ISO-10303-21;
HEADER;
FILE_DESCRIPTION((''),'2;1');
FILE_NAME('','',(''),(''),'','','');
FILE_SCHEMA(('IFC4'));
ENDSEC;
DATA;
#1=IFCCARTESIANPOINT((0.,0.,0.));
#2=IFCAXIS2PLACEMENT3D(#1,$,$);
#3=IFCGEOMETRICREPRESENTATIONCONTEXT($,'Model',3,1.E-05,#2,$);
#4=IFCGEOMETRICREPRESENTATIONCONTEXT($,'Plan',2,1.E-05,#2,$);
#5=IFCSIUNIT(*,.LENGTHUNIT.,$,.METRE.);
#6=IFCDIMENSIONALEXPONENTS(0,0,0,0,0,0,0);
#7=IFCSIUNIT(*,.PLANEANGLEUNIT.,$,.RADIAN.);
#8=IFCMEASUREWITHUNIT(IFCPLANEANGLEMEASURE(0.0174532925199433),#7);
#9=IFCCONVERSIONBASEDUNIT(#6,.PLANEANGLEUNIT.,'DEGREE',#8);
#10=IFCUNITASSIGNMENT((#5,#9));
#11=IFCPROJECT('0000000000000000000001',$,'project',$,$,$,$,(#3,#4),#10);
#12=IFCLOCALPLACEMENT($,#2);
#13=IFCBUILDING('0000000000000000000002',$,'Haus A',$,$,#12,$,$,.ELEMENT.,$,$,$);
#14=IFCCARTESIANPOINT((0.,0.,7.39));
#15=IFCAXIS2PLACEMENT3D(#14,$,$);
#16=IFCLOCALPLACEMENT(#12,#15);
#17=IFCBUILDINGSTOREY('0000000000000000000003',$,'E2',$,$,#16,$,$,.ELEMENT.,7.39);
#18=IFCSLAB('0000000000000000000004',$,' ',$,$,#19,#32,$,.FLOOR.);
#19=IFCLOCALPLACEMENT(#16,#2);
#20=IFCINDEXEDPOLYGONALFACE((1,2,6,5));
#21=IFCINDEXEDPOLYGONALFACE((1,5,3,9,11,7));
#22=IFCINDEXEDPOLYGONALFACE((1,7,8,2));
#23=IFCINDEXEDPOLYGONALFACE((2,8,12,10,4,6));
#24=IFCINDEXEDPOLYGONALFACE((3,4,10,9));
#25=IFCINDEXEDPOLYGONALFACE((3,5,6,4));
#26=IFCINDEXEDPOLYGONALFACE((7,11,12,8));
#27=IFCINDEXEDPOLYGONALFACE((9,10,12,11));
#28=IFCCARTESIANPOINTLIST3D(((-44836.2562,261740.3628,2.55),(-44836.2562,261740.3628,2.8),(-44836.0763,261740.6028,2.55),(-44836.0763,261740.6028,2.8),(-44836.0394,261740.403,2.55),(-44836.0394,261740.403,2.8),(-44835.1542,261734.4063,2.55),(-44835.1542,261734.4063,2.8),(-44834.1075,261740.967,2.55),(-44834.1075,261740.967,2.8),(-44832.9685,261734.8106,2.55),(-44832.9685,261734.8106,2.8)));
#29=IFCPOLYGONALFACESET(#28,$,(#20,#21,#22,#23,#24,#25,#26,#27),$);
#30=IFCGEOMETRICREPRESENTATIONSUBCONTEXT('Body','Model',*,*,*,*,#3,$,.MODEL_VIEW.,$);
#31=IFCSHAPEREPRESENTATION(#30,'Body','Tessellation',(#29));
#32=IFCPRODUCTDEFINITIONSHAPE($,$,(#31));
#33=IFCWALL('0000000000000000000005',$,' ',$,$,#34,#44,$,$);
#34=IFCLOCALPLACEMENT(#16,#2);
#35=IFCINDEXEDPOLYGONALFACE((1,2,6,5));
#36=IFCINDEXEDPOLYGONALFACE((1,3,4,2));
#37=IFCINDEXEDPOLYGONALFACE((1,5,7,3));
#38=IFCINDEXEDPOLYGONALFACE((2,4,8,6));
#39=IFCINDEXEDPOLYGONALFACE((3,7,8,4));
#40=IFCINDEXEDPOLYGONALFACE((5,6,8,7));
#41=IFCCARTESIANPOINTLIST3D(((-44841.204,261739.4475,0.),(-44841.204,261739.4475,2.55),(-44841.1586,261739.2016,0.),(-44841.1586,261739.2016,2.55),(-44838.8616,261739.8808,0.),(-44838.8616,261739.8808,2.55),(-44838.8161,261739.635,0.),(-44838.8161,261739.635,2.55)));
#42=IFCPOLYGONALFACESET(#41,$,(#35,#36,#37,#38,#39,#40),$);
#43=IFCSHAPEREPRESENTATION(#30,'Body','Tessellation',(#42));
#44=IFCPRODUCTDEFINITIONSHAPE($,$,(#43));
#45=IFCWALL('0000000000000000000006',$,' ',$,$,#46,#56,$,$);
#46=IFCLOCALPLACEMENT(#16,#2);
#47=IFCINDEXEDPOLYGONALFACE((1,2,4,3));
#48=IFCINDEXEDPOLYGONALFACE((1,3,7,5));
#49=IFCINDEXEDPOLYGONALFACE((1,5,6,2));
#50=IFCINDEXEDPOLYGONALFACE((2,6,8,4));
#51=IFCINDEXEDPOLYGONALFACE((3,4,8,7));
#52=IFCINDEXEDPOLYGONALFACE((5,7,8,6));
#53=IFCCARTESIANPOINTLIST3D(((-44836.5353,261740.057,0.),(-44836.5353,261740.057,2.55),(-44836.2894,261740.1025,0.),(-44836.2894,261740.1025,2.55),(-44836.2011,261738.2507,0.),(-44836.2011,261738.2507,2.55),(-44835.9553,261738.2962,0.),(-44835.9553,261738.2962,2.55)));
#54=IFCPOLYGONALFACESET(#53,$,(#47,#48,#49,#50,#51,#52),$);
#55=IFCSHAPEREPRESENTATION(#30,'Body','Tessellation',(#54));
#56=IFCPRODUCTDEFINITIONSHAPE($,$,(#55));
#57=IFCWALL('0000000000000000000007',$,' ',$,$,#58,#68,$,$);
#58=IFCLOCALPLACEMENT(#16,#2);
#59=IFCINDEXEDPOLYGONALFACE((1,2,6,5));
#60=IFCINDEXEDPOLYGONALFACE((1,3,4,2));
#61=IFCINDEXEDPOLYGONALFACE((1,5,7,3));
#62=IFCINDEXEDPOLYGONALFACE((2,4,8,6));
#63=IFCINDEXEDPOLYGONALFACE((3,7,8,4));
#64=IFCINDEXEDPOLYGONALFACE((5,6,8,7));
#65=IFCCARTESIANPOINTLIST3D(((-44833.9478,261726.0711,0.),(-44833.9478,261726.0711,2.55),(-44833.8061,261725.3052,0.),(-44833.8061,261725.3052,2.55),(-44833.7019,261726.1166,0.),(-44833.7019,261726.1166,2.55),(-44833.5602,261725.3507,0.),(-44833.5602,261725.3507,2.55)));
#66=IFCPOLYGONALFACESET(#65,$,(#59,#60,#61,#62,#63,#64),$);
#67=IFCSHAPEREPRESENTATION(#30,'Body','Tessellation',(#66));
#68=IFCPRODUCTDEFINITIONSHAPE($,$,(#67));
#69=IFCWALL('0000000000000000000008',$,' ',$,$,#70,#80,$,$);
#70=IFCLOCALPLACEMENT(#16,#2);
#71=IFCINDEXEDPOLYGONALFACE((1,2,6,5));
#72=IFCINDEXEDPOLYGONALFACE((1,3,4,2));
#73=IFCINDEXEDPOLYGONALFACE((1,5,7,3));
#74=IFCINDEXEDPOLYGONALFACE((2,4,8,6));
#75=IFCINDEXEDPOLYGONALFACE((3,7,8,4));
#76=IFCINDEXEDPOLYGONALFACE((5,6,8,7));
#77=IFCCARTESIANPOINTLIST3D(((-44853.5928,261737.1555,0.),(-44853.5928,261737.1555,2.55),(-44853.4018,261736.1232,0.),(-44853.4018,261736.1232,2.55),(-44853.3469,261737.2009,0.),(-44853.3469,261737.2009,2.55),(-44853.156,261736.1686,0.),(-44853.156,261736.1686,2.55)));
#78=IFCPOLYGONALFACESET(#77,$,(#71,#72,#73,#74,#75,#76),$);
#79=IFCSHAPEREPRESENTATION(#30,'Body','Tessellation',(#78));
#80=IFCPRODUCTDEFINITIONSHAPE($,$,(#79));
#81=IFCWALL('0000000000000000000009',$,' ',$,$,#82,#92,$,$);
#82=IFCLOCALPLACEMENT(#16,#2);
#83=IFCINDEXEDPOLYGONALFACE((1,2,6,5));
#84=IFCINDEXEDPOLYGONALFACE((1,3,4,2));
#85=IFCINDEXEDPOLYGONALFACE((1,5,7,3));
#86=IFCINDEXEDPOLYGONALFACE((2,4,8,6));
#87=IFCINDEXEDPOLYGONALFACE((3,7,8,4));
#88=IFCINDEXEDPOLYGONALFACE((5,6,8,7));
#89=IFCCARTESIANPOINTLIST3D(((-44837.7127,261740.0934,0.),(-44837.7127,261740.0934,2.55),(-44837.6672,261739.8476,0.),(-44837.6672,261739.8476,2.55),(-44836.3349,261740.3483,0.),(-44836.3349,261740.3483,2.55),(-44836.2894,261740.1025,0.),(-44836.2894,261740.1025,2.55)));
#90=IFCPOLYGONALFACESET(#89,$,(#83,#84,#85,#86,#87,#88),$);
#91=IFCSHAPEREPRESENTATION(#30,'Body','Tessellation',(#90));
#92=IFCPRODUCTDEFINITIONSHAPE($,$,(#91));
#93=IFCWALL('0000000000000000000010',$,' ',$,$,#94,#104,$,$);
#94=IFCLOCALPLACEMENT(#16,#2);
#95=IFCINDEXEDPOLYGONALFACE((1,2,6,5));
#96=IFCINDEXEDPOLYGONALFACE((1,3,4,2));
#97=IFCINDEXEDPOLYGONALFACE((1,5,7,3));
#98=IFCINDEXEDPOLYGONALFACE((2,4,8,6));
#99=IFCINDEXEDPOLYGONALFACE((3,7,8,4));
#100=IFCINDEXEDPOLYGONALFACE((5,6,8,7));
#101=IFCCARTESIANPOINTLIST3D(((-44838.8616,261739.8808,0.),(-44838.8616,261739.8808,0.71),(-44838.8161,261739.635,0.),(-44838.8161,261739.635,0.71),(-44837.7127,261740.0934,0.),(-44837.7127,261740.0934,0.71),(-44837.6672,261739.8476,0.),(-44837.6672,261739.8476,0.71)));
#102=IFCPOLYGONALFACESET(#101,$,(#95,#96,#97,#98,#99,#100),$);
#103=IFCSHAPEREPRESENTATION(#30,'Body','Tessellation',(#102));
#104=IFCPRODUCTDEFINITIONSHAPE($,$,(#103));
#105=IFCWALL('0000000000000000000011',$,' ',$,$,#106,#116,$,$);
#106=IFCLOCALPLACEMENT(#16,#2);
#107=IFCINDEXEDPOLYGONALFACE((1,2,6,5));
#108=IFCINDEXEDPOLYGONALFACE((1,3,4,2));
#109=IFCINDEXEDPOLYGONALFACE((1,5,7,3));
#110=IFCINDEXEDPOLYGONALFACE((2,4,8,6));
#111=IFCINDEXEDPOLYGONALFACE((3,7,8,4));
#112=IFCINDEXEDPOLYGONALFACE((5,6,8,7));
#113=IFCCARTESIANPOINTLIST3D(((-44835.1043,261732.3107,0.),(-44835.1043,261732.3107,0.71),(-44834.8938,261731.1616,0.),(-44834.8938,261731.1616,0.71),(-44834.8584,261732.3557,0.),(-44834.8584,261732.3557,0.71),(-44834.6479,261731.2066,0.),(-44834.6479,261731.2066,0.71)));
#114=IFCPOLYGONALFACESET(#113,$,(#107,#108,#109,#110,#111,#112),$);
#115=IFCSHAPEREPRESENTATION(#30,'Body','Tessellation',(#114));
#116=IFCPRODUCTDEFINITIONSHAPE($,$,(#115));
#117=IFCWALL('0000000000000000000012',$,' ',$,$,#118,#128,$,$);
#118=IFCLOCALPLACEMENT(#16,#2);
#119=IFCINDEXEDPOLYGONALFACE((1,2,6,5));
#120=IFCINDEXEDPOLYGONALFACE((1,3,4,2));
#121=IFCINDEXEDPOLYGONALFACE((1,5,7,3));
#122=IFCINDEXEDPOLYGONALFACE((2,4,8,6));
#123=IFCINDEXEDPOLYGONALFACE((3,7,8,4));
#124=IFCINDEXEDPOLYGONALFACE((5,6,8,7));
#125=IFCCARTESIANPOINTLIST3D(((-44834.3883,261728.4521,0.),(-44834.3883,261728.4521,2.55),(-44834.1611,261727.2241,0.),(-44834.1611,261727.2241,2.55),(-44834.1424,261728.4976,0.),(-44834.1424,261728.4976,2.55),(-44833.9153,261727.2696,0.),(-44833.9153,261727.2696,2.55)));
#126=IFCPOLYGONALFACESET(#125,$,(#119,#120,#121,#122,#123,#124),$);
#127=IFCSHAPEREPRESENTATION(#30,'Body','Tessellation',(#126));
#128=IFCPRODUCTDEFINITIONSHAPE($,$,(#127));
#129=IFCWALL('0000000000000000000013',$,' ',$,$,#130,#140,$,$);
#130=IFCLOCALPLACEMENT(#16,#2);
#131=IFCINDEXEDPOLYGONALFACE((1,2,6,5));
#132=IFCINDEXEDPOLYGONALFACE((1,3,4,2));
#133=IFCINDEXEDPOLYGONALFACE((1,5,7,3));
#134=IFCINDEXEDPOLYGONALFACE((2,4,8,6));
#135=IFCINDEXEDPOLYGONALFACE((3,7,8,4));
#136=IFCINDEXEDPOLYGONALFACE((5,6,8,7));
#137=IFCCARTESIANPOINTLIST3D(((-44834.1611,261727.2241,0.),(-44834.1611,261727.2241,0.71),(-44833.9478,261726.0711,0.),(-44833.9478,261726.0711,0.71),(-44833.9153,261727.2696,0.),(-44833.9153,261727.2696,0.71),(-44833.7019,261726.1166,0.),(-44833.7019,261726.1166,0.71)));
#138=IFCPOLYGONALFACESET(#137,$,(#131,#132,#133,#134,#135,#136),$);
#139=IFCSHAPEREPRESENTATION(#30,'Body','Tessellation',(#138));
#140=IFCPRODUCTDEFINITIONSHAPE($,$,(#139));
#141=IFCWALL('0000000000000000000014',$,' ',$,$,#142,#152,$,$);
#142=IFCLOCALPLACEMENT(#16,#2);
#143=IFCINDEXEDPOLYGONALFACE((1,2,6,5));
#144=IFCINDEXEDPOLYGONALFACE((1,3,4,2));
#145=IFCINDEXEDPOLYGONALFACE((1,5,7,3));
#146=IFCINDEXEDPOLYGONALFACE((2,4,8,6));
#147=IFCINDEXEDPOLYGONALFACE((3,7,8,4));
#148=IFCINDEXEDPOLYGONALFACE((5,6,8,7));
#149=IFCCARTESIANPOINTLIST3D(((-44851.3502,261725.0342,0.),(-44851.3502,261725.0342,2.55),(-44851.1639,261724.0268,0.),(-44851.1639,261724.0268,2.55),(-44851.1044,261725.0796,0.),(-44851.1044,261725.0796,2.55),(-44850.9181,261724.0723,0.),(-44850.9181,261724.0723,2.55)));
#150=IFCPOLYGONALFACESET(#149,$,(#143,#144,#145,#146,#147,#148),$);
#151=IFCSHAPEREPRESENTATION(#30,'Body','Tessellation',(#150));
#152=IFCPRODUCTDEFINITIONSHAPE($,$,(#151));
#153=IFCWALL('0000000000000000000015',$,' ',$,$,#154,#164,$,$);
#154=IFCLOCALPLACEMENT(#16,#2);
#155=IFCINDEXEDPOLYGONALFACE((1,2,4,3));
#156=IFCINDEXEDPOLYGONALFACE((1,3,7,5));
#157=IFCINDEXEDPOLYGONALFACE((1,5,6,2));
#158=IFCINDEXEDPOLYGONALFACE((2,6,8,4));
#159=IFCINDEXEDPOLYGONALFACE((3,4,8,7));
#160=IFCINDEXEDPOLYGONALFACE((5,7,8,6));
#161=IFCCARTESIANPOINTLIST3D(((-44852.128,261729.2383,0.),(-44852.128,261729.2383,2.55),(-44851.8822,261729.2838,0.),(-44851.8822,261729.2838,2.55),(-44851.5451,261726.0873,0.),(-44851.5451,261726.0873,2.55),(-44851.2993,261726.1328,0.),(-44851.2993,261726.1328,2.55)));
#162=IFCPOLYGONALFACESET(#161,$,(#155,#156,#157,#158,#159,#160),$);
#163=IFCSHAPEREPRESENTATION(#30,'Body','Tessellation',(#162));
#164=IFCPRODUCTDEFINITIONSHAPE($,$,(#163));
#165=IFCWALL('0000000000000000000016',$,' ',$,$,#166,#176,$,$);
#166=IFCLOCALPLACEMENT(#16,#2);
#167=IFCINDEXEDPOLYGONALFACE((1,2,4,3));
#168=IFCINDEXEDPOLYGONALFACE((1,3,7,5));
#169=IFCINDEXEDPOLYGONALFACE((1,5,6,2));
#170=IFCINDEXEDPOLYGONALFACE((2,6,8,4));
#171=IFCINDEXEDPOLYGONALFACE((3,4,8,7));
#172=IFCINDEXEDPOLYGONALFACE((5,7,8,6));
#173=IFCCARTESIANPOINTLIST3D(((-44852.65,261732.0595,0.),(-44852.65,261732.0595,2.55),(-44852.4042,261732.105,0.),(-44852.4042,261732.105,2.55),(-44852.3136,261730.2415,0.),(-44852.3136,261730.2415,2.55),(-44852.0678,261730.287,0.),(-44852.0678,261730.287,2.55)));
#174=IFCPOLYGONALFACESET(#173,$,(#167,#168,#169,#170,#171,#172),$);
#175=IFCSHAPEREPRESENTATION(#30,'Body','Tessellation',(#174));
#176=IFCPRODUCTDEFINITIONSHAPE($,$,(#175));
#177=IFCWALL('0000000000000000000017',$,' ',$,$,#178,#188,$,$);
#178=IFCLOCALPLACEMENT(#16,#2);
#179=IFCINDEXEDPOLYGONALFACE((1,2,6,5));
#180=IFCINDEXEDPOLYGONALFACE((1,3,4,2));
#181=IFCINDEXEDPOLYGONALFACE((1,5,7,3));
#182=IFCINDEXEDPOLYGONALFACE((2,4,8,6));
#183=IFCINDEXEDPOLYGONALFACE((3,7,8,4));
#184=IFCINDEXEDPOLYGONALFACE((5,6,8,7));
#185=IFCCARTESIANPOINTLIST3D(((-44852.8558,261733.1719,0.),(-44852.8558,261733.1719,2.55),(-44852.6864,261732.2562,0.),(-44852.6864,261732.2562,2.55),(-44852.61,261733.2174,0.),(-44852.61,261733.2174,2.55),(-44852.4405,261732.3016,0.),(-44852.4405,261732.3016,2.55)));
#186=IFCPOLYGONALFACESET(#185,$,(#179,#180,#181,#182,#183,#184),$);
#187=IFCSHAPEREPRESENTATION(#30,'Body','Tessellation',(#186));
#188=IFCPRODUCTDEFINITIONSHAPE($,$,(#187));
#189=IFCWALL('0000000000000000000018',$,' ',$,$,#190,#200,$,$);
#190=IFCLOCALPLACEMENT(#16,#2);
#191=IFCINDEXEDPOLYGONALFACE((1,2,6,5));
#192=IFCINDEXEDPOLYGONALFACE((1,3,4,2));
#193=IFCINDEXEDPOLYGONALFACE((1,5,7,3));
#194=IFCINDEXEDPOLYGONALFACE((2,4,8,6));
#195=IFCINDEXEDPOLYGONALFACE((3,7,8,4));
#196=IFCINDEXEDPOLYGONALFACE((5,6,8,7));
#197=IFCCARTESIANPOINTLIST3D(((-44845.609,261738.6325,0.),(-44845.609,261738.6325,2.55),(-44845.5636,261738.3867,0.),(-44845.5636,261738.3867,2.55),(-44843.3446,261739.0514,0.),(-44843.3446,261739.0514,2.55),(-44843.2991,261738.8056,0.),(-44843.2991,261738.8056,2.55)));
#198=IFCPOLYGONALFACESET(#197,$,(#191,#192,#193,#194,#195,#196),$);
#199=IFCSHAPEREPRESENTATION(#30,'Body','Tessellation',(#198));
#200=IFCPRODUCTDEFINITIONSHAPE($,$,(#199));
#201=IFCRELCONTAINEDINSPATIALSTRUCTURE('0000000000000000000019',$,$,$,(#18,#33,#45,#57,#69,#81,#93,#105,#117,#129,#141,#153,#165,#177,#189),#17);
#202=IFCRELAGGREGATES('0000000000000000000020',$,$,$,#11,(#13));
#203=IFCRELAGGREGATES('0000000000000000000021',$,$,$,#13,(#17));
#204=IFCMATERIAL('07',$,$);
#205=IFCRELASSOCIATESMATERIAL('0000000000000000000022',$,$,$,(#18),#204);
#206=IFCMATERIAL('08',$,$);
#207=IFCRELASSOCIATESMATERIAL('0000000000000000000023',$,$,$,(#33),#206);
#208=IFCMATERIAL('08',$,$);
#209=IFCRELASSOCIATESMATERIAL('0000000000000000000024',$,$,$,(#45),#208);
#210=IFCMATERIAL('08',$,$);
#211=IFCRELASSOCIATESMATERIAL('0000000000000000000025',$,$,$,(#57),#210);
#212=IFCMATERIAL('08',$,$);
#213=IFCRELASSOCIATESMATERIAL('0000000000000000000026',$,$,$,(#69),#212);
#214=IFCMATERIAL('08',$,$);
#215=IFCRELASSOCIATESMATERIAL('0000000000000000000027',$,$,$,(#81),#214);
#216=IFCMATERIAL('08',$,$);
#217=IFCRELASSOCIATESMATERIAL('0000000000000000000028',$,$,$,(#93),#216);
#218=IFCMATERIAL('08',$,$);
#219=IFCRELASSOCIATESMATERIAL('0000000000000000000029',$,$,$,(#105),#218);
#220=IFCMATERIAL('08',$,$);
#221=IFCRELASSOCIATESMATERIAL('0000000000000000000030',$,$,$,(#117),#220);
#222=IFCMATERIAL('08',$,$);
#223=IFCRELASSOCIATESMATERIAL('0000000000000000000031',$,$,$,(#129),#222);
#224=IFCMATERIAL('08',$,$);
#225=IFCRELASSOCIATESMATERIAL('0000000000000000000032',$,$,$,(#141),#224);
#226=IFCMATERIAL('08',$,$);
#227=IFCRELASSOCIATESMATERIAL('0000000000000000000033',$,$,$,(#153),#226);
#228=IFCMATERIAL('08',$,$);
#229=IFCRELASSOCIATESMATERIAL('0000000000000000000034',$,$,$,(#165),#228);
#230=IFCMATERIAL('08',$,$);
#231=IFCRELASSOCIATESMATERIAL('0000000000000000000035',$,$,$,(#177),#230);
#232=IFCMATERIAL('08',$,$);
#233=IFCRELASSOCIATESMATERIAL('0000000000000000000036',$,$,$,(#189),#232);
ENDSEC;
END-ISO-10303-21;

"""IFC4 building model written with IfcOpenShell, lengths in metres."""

from ifc_helpers import new_model, entity, si_unit, converted_unit, frame, frame_2d, origin, origin_with_axes, place, context, subcontext, project, spatial, polyline, rectangle, outline, extrude, material, element, save


model = new_model("IFC4")

# Units and contexts
model_context = context("Model", 3, precision=1e-05, world=origin())
plan_context = context("Plan", 2, precision=1e-05, world=origin())
body_context = subcontext(model_context, "Body", "Model", "MODEL_VIEW")
ifc_project = project(units=[si_unit("LENGTHUNIT", "METRE"), converted_unit("PLANEANGLEUNIT", "DEGREE", entity("IfcPlaneAngleMeasure", 0.0174532925199433), si_unit("PLANEANGLEUNIT", "RADIAN"), dimensions=[0, 0, 0, 0, 0, 0, 0])], contexts=[model_context, plan_context])

# Building, storey
building_placement = place(None, origin())
building = spatial("IfcBuilding", under=ifc_project, at=building_placement, Name="Haus A", CompositionType="ELEMENT")
storey_placement = place(building_placement, frame((0.0, 0.0, 7.39)))
storey = spatial("IfcBuildingStorey", under=building, at=storey_placement, Name="E2", CompositionType="ELEMENT", Elevation=7.39)

# Slab
ifc_material_1 = material(Name="07")
slab_placement = place(storey_placement, frame((-44836.2562, 261734.4063, 2.55)))
element("IfcSlab", 1, at=slab_placement, inside=storey, material=ifc_material_1, Name=" ", PredefinedType="FLOOR", context=body_context, shape_type="SweptSolid", body=[
    extrude(outline(polyline([(1.102, 0.0), (3.2878, 0.4044), (2.1488, 6.5608), (0.1799, 6.1965), (0.2169, 5.9967), (0.0, 5.9566), (1.102, 0.0)])), origin_with_axes(), (0.0, 0.0, 1.0), 0.25),
])

# Walls
ifc_material_2 = material(Name="08")
wall_1_placement = place(storey_placement, frame((-44838.8616, 261739.8808, 0.0), z_axis=(0.0, 0.0, 1.0), x_axis=(-0.983313, -0.18192, 0.0)))
element("IfcWall", 2, at=wall_1_placement, inside=storey, material=ifc_material_2, Name=" ", context=body_context, shape_type="SweptSolid", body=[
    extrude(rectangle(XDim=2.3822, YDim=0.25, at=frame_2d((1.1911, 0.125), x_axis=(1.0, 0.0))), origin_with_axes(), (0.0, 0.0, 1.0), 2.55),
])
ifc_material_3 = material(Name="08")
wall_2_placement = place(storey_placement, frame((-44835.9553, 261738.2962, 0.0), z_axis=(0.0, 0.0, 1.0), x_axis=(-0.18192, 0.983313, 0.0)))
element("IfcWall", 3, at=wall_2_placement, inside=storey, material=ifc_material_3, Name=" ", context=body_context, shape_type="SweptSolid", body=[
    extrude(rectangle(XDim=1.837, YDim=0.25, at=frame_2d((0.9185, 0.125), x_axis=(1.0, 0.0))), origin_with_axes(), (0.0, 0.0, 1.0), 2.55),
])
ifc_material_4 = material(Name="08")
wall_3_placement = place(storey_placement, frame((-44833.5602, 261725.3507, 0.0), z_axis=(0.0, 0.0, 1.0), x_axis=(-0.18192, 0.983313, 0.0)))
element("IfcWall", 4, at=wall_3_placement, inside=storey, material=ifc_material_4, Name=" ", context=body_context, shape_type="SweptSolid", body=[
    extrude(rectangle(XDim=0.7789, YDim=0.25, at=frame_2d((0.3895, 0.125), x_axis=(1.0, 0.0))), origin_with_axes(), (0.0, 0.0, 1.0), 2.55),
])
ifc_material_5 = material(Name="08")
wall_4_placement = place(storey_placement, frame((-44853.5928, 261737.1555, 0.0), z_axis=(0.0, 0.0, 1.0), x_axis=(0.18192, -0.983313, 0.0)))
element("IfcWall", 5, at=wall_4_placement, inside=storey, material=ifc_material_5, Name=" ", context=body_context, shape_type="SweptSolid", body=[
    extrude(rectangle(XDim=1.0498, YDim=0.25, at=frame_2d((0.5249, 0.125), x_axis=(1.0, 0.0))), origin_with_axes(), (0.0, 0.0, 1.0), 2.55),
])
ifc_material_6 = material(Name="08")
wall_5_placement = place(storey_placement, frame((-44836.3349, 261740.3483, 0.0), z_axis=(0.0, 0.0, 1.0), x_axis=(-0.983313, -0.18192, 0.0)))
element("IfcWall", 6, at=wall_5_placement, inside=storey, material=ifc_material_6, Name=" ", context=body_context, shape_type="SweptSolid", body=[
    extrude(rectangle(XDim=1.4012, YDim=0.25, at=frame_2d((0.7006, 0.125), x_axis=(1.0, 0.0))), origin_with_axes(), (0.0, 0.0, 1.0), 2.55),
])
ifc_material_7 = material(Name="08")
wall_6_placement = place(storey_placement, frame((-44837.7127, 261740.0934, 0.0), z_axis=(0.0, 0.0, 1.0), x_axis=(-0.983313, -0.18192, 0.0)))
element("IfcWall", 7, at=wall_6_placement, inside=storey, material=ifc_material_7, Name=" ", context=body_context, shape_type="SweptSolid", body=[
    extrude(rectangle(XDim=1.1684, YDim=0.25, at=frame_2d((0.5842, 0.125), x_axis=(1.0, 0.0))), origin_with_axes(), (0.0, 0.0, 1.0), 0.71),
])
ifc_material_8 = material(Name="08")
wall_7_placement = place(storey_placement, frame((-44834.6479, 261731.2066, 0.0), z_axis=(0.0, 0.0, 1.0), x_axis=(-0.180125, 0.983644, 0.0)))
element("IfcWall", 8, at=wall_7_placement, inside=storey, material=ifc_material_8, Name=" ", context=body_context, shape_type="SweptSolid", body=[
    extrude(rectangle(XDim=1.1682, YDim=0.25, at=frame_2d((0.5841, 0.125), x_axis=(1.0, 0.0))), origin_with_axes(), (0.0, 0.0, 1.0), 0.71),
])
ifc_material_9 = material(Name="08")
wall_8_placement = place(storey_placement, frame((-44833.9153, 261727.2696, 0.0), z_axis=(0.0, 0.0, 1.0), x_axis=(-0.18192, 0.983313, 0.0)))
element("IfcWall", 9, at=wall_8_placement, inside=storey, material=ifc_material_9, Name=" ", context=body_context, shape_type="SweptSolid", body=[
    extrude(rectangle(XDim=1.2488, YDim=0.25, at=frame_2d((0.6244, 0.125), x_axis=(1.0, 0.0))), origin_with_axes(), (0.0, 0.0, 1.0), 2.55),
])
ifc_material_10 = material(Name="08")
wall_9_placement = place(storey_placement, frame((-44833.7019, 261726.1166, 0.0), z_axis=(0.0, 0.0, 1.0), x_axis=(-0.18192, 0.983313, 0.0)))
element("IfcWall", 10, at=wall_9_placement, inside=storey, material=ifc_material_10, Name=" ", context=body_context, shape_type="SweptSolid", body=[
    extrude(rectangle(XDim=1.1726, YDim=0.25, at=frame_2d((0.5863, 0.125), x_axis=(1.0, 0.0))), origin_with_axes(), (0.0, 0.0, 1.0), 0.71),
])
ifc_material_11 = material(Name="08")
wall_10_placement = place(storey_placement, frame((-44851.3502, 261725.0342, 0.0), z_axis=(0.0, 0.0, 1.0), x_axis=(0.18192, -0.983313, 0.0)))
element("IfcWall", 11, at=wall_10_placement, inside=storey, material=ifc_material_11, Name=" ", context=body_context, shape_type="SweptSolid", body=[
    extrude(rectangle(XDim=1.0244, YDim=0.25, at=frame_2d((0.5122, 0.125), x_axis=(1.0, 0.0))), origin_with_axes(), (0.0, 0.0, 1.0), 2.55),
])
ifc_material_12 = material(Name="08")
wall_11_placement = place(storey_placement, frame((-44852.128, 261729.2383, 0.0), z_axis=(0.0, 0.0, 1.0), x_axis=(0.18192, -0.983313, 0.0)))
element("IfcWall", 12, at=wall_11_placement, inside=storey, material=ifc_material_12, Name=" ", context=body_context, shape_type="SweptSolid", body=[
    extrude(rectangle(XDim=3.2045, YDim=0.25, at=frame_2d((1.6023, 0.125), x_axis=(1.0, 0.0))), origin_with_axes(), (0.0, 0.0, 1.0), 2.55),
])
ifc_material_13 = material(Name="08")
wall_12_placement = place(storey_placement, frame((-44852.65, 261732.0595, 0.0), z_axis=(0.0, 0.0, 1.0), x_axis=(0.18192, -0.983313, 0.0)))
element("IfcWall", 13, at=wall_12_placement, inside=storey, material=ifc_material_13, Name=" ", context=body_context, shape_type="SweptSolid", body=[
    extrude(rectangle(XDim=1.8489, YDim=0.25, at=frame_2d((0.9244, 0.125), x_axis=(1.0, 0.0))), origin_with_axes(), (0.0, 0.0, 1.0), 2.55),
])
ifc_material_14 = material(Name="08")
wall_13_placement = place(storey_placement, frame((-44852.8558, 261733.1719, 0.0), z_axis=(0.0, 0.0, 1.0), x_axis=(0.18192, -0.983313, 0.0)))
element("IfcWall", 14, at=wall_13_placement, inside=storey, material=ifc_material_14, Name=" ", context=body_context, shape_type="SweptSolid", body=[
    extrude(rectangle(XDim=0.9313, YDim=0.25, at=frame_2d((0.4656, 0.125), x_axis=(1.0, 0.0))), origin_with_axes(), (0.0, 0.0, 1.0), 2.55),
])
ifc_material_15 = material(Name="08")
wall_14_placement = place(storey_placement, frame((-44843.3446, 261739.0514, 0.0), z_axis=(0.0, 0.0, 1.0), x_axis=(-0.983313, -0.18192, 0.0)))
element("IfcWall", 15, at=wall_14_placement, inside=storey, material=ifc_material_15, Name=" ", context=body_context, shape_type="SweptSolid", body=[
    extrude(rectangle(XDim=2.3028, YDim=0.25, at=frame_2d((1.1514, 0.125), x_axis=(1.0, 0.0))), origin_with_axes(), (0.0, 0.0, 1.0), 2.55),
])

save(model, "model.ifc")
